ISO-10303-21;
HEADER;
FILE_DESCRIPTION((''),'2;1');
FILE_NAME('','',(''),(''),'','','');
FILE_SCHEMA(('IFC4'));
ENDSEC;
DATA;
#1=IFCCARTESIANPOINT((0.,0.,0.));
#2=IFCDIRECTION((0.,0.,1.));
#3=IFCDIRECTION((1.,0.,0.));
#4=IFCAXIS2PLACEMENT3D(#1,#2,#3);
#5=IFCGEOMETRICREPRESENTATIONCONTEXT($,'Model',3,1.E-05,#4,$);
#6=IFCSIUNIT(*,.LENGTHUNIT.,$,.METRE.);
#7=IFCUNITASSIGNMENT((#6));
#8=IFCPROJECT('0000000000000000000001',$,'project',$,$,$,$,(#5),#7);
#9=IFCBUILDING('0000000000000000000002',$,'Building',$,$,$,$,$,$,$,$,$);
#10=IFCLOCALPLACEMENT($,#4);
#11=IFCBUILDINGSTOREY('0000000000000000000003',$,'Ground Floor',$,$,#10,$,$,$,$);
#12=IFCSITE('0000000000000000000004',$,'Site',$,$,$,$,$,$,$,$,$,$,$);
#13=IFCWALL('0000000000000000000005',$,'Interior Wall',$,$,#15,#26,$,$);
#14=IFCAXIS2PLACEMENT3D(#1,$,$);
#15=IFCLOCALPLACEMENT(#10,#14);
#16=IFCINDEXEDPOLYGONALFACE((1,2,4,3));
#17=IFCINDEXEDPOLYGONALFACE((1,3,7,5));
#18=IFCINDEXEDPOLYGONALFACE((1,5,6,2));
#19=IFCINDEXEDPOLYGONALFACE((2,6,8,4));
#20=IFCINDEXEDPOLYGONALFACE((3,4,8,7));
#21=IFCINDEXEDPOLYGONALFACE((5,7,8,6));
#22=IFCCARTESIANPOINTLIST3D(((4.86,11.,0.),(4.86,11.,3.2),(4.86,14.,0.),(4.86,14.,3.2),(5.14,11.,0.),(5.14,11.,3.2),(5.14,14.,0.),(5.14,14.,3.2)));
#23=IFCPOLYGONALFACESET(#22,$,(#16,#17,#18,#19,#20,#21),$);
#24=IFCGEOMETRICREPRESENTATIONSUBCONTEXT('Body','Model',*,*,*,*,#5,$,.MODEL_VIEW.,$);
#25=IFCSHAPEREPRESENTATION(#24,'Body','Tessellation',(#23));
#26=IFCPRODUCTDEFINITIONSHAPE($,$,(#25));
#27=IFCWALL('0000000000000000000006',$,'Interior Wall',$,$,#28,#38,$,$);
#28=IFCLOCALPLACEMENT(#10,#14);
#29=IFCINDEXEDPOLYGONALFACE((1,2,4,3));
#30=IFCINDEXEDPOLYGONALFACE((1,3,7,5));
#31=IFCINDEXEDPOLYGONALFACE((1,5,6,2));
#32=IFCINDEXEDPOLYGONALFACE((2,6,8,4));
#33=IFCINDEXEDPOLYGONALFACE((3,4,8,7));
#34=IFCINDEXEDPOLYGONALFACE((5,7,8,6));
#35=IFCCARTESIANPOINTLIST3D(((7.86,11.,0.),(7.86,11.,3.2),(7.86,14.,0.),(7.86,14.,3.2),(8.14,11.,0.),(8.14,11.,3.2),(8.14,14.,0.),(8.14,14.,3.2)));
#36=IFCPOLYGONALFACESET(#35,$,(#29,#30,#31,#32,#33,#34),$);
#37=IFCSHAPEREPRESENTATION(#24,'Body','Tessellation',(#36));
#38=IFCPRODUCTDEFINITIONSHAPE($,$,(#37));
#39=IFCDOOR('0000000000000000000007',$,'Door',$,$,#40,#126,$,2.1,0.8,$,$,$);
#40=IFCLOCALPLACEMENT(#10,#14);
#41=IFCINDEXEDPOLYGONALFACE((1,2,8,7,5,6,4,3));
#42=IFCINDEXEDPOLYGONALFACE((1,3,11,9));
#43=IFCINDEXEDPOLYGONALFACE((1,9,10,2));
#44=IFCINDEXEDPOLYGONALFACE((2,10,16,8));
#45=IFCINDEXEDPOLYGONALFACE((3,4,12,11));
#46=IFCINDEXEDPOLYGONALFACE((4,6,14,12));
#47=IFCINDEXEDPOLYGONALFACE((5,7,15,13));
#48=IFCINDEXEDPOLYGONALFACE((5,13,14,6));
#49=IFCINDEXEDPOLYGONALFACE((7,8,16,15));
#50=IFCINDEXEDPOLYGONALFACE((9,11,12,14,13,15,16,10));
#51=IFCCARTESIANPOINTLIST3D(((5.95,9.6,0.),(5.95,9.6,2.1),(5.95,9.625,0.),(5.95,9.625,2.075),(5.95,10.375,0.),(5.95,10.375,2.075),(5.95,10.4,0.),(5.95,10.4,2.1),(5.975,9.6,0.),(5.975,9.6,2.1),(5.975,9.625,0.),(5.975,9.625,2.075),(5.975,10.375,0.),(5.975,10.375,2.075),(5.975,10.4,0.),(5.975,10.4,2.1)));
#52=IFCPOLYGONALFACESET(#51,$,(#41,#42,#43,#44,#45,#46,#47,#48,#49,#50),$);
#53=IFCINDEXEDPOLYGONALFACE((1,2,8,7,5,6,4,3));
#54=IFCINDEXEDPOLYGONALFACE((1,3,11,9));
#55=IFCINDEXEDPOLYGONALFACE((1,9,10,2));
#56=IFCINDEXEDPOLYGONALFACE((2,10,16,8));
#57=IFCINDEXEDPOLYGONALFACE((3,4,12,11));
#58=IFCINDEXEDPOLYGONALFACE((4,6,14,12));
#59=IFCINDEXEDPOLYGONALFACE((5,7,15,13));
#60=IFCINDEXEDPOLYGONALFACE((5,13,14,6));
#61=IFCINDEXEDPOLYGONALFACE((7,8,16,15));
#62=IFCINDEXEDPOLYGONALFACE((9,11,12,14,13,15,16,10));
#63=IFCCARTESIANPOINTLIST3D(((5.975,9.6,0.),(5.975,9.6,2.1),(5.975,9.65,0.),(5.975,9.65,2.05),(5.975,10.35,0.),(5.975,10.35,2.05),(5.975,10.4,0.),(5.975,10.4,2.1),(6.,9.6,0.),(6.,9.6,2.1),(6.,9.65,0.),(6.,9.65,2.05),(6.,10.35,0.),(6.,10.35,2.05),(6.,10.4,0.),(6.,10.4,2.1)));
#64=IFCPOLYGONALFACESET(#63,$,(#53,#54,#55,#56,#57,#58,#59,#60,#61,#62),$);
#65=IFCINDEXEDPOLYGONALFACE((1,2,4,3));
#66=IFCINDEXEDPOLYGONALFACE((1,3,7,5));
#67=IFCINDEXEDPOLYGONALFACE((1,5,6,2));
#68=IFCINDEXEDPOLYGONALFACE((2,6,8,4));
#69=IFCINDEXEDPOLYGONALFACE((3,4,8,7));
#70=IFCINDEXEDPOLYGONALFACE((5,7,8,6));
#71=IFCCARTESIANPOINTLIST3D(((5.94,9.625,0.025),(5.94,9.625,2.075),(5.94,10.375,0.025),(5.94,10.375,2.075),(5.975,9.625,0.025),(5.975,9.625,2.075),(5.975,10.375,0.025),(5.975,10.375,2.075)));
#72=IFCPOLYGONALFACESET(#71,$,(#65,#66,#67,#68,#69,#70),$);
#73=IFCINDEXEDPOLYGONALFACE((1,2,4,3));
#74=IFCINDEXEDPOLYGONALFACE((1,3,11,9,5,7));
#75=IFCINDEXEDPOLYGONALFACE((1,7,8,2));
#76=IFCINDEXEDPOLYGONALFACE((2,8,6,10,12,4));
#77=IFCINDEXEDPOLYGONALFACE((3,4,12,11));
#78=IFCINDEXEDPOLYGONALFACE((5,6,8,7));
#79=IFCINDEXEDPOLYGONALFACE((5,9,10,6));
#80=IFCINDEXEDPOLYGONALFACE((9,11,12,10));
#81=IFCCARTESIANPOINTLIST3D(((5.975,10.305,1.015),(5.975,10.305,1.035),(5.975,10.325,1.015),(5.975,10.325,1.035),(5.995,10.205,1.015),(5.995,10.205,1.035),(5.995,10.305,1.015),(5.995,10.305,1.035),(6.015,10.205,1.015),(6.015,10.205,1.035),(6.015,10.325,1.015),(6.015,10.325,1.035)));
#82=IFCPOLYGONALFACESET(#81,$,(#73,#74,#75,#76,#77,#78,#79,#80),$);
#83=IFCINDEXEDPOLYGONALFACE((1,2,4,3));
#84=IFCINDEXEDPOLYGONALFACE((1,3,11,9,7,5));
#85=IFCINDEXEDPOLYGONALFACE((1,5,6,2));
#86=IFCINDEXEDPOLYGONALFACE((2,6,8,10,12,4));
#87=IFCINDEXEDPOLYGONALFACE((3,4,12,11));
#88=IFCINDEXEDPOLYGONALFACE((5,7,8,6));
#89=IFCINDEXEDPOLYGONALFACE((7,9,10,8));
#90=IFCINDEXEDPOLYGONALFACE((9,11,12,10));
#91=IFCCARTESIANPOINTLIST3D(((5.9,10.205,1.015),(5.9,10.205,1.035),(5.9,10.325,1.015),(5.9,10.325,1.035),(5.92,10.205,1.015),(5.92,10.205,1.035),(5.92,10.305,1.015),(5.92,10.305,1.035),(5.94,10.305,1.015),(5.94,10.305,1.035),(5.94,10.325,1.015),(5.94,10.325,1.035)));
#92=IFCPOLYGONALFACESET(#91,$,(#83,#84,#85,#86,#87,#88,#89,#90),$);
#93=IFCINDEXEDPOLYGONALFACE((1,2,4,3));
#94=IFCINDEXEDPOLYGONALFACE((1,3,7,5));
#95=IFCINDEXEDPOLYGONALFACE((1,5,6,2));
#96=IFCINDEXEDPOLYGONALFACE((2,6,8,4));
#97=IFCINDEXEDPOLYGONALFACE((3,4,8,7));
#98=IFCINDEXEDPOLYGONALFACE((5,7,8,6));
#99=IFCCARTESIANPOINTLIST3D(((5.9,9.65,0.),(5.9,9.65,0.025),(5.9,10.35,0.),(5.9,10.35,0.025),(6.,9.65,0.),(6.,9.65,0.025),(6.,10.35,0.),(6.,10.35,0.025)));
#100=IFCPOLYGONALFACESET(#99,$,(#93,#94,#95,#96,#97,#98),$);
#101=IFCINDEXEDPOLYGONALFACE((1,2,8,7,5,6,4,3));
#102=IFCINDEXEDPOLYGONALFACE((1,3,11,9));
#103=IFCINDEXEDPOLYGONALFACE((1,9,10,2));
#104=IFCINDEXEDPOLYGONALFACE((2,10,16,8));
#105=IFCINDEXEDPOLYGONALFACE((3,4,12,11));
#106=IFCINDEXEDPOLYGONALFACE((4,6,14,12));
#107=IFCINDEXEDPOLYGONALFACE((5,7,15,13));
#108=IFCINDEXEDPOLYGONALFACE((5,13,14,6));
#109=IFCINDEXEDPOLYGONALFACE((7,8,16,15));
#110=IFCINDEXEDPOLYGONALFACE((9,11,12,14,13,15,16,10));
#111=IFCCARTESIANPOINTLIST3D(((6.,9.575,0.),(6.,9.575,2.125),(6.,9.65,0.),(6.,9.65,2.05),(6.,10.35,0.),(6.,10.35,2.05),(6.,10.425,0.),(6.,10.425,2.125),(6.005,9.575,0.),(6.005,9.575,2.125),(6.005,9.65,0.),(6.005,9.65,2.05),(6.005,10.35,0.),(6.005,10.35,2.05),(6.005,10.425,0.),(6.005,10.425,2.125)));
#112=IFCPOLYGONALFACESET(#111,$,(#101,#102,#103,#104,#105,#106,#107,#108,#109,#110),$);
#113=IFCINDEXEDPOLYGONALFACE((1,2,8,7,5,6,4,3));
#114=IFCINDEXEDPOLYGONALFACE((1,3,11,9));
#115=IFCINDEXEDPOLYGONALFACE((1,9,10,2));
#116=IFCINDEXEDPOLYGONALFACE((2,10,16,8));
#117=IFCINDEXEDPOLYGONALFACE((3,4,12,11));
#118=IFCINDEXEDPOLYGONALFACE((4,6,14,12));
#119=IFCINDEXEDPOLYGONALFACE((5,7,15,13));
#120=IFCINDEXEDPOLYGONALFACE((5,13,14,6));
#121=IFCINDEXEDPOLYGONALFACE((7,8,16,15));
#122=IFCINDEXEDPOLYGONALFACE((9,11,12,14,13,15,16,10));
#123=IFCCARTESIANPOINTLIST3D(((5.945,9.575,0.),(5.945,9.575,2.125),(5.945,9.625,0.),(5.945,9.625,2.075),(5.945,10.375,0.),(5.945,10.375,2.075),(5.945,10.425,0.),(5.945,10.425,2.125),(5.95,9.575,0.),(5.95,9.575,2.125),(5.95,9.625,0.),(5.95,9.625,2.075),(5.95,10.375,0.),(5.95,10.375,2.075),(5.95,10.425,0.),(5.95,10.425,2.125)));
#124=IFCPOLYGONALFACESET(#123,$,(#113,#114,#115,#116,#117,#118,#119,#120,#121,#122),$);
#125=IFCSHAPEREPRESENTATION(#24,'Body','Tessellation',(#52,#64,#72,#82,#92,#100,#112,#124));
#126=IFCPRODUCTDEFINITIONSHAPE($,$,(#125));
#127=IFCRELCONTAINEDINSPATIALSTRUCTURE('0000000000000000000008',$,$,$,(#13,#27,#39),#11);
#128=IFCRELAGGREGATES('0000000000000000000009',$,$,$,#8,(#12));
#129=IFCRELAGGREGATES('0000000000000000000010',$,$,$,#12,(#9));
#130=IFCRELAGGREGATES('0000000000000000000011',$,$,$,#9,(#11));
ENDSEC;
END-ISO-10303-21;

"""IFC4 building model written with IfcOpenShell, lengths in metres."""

from ifc_helpers import new_model, si_unit, frame, origin_with_axes, place, context, subcontext, project, spatial, line, indexed_curve, outline, extrude, element, save


model = new_model("IFC4")

# Units and contexts
model_context = context("Model", 3, precision=1e-05, world=origin_with_axes())
body_context = subcontext(model_context, "Body", "Model", "MODEL_VIEW")
ifc_project = project(units=[si_unit("LENGTHUNIT", "METRE")], contexts=[model_context])

# Site, building, storey
site = spatial("IfcSite", under=ifc_project, Name="Site")
building = spatial("IfcBuilding", under=site, Name="Building")
storey_placement = place(None, origin_with_axes())
storey = spatial("IfcBuildingStorey", under=building, at=storey_placement, Name="Ground Floor")

# Walls
for number, where, z_axis, x_axis, name in (
    (1, (5.0, 11.0, 0.0), (0.0, 0.0, 1.0), (0.0, 1.0, 0.0), "Interior Wall"),
    (2, (8.0, 11.0, 0.0), (0.0, 0.0, 1.0), (0.0, 1.0, 0.0), "Interior Wall"),
):
    element("IfcWall", number, at=place(storey_placement, frame(where, z_axis=z_axis, x_axis=x_axis)), inside=storey, Name=name, context=body_context, shape_type="SweptSolid", body=[
        extrude(outline(indexed_curve([(0.0, 0.0), (0.0, 0.28), (3.0, 0.28), (3.0, 0.0), (0.0, 0.0)], self_intersect=False)), frame((0.0, -0.14, 0.0), z_axis=(0.0, 0.0, 1.0), x_axis=(1.0, 0.0, 0.0)), (0.0, 0.0, 1.0), 3.2),
    ])

# Door
door_1_placement = place(storey_placement, frame((6.0, 9.6, 0.0), z_axis=(0.0, 0.0, 1.0), x_axis=(0.0, 1.0, 0.0)))
element("IfcDoor", 3, at=door_1_placement, inside=storey, Name="Door", OverallHeight=2.1, OverallWidth=0.8, context=body_context, shape_type="SweptSolid", body=[
    extrude(outline(indexed_curve([(0.0, 0.0), (0.0, 2.1), (0.8, 2.1), (0.8, 0.0), (0.775, 0.0), (0.775, 2.075), (0.025, 2.075), (0.025, 0.0)], segments=[line(1, 2, 3, 4, 5, 6, 7, 8, 1)])), frame((0.0, 0.025, 0.0), z_axis=(0.0, -1.0, 0.0), x_axis=(1.0, 0.0, 0.0)), (0.0, 0.0, -1.0), 0.025),
    extrude(outline(indexed_curve([(0.0, 0.0), (0.0, 2.1), (0.8, 2.1), (0.8, 0.0), (0.75, 0.0), (0.75, 2.05), (0.05, 2.05), (0.05, 0.0)], segments=[line(1, 2, 3, 4, 5, 6, 7, 8, 1)])), frame((0.0, 0.0, 0.0), z_axis=(0.0, -1.0, 0.0), x_axis=(1.0, 0.0, 0.0)), (0.0, 0.0, -1.0), 0.025),
    extrude(outline(indexed_curve([(0.0, 0.0), (0.75, 0.0), (0.75, 0.035), (0.0, 0.035)], segments=[line(1, 2, 3, 4, 1)])), frame((0.025, 0.025, 0.025), z_axis=(0.0, 0.0, 1.0), x_axis=(1.0, 0.0, 0.0)), (0.0, 0.0, 1.0), 2.05),
    extrude(outline(indexed_curve([(0.0, 0.0), (0.0, -0.04), (-0.12, -0.04), (-0.12, -0.02), (-0.02, -0.02), (-0.02, 0.0)], segments=[line(1, 2, 3, 4, 5, 6, 1)])), frame((0.725, 0.025, 1.015), z_axis=(0.0, 0.0, 1.0), x_axis=(1.0, 0.0, 0.0)), (0.0, 0.0, 1.0), 0.02),
    extrude(outline(indexed_curve([(0.0, 0.0), (0.0, 0.04), (-0.12, 0.04), (-0.12, 0.02), (-0.02, 0.02), (-0.02, 0.0)], segments=[line(1, 2, 3, 4, 5, 6, 1)])), frame((0.725, 0.06, 1.015), z_axis=(0.0, 0.0, 1.0), x_axis=(1.0, 0.0, 0.0)), (0.0, 0.0, 1.0), 0.02),
    extrude(outline(indexed_curve([(0.0, 0.0), (0.7, 0.0), (0.7, 0.1), (0.0, 0.1)], segments=[line(1, 2, 3, 4, 1)])), frame((0.05, 0.0, 0.0), z_axis=(0.0, 0.0, 1.0), x_axis=(1.0, 0.0, 0.0)), (0.0, 0.0, 1.0), 0.025),
    extrude(outline(indexed_curve([(0.0, 0.0), (0.0, 2.125), (0.85, 2.125), (0.85, 0.0), (0.775, 0.0), (0.775, 2.05), (0.075, 2.05), (0.075, 0.0)], segments=[line(1, 2, 3, 4, 5, 6, 7, 8, 1)])), frame((-0.025, -0.005, 0.0), z_axis=(0.0, -1.0, 0.0), x_axis=(1.0, 0.0, 0.0)), (0.0, 0.0, -1.0), 0.005),
    extrude(outline(indexed_curve([(0.0, 0.0), (0.0, 2.125), (0.85, 2.125), (0.85, 0.0), (0.8, 0.0), (0.8, 2.075), (0.05, 2.075), (0.05, 0.0)], segments=[line(1, 2, 3, 4, 5, 6, 7, 8, 1)])), frame((-0.025, 0.05, 0.0), z_axis=(0.0, -1.0, 0.0), x_axis=(1.0, 0.0, 0.0)), (0.0, 0.0, -1.0), 0.005),
])

save(model, "model.ifc")
